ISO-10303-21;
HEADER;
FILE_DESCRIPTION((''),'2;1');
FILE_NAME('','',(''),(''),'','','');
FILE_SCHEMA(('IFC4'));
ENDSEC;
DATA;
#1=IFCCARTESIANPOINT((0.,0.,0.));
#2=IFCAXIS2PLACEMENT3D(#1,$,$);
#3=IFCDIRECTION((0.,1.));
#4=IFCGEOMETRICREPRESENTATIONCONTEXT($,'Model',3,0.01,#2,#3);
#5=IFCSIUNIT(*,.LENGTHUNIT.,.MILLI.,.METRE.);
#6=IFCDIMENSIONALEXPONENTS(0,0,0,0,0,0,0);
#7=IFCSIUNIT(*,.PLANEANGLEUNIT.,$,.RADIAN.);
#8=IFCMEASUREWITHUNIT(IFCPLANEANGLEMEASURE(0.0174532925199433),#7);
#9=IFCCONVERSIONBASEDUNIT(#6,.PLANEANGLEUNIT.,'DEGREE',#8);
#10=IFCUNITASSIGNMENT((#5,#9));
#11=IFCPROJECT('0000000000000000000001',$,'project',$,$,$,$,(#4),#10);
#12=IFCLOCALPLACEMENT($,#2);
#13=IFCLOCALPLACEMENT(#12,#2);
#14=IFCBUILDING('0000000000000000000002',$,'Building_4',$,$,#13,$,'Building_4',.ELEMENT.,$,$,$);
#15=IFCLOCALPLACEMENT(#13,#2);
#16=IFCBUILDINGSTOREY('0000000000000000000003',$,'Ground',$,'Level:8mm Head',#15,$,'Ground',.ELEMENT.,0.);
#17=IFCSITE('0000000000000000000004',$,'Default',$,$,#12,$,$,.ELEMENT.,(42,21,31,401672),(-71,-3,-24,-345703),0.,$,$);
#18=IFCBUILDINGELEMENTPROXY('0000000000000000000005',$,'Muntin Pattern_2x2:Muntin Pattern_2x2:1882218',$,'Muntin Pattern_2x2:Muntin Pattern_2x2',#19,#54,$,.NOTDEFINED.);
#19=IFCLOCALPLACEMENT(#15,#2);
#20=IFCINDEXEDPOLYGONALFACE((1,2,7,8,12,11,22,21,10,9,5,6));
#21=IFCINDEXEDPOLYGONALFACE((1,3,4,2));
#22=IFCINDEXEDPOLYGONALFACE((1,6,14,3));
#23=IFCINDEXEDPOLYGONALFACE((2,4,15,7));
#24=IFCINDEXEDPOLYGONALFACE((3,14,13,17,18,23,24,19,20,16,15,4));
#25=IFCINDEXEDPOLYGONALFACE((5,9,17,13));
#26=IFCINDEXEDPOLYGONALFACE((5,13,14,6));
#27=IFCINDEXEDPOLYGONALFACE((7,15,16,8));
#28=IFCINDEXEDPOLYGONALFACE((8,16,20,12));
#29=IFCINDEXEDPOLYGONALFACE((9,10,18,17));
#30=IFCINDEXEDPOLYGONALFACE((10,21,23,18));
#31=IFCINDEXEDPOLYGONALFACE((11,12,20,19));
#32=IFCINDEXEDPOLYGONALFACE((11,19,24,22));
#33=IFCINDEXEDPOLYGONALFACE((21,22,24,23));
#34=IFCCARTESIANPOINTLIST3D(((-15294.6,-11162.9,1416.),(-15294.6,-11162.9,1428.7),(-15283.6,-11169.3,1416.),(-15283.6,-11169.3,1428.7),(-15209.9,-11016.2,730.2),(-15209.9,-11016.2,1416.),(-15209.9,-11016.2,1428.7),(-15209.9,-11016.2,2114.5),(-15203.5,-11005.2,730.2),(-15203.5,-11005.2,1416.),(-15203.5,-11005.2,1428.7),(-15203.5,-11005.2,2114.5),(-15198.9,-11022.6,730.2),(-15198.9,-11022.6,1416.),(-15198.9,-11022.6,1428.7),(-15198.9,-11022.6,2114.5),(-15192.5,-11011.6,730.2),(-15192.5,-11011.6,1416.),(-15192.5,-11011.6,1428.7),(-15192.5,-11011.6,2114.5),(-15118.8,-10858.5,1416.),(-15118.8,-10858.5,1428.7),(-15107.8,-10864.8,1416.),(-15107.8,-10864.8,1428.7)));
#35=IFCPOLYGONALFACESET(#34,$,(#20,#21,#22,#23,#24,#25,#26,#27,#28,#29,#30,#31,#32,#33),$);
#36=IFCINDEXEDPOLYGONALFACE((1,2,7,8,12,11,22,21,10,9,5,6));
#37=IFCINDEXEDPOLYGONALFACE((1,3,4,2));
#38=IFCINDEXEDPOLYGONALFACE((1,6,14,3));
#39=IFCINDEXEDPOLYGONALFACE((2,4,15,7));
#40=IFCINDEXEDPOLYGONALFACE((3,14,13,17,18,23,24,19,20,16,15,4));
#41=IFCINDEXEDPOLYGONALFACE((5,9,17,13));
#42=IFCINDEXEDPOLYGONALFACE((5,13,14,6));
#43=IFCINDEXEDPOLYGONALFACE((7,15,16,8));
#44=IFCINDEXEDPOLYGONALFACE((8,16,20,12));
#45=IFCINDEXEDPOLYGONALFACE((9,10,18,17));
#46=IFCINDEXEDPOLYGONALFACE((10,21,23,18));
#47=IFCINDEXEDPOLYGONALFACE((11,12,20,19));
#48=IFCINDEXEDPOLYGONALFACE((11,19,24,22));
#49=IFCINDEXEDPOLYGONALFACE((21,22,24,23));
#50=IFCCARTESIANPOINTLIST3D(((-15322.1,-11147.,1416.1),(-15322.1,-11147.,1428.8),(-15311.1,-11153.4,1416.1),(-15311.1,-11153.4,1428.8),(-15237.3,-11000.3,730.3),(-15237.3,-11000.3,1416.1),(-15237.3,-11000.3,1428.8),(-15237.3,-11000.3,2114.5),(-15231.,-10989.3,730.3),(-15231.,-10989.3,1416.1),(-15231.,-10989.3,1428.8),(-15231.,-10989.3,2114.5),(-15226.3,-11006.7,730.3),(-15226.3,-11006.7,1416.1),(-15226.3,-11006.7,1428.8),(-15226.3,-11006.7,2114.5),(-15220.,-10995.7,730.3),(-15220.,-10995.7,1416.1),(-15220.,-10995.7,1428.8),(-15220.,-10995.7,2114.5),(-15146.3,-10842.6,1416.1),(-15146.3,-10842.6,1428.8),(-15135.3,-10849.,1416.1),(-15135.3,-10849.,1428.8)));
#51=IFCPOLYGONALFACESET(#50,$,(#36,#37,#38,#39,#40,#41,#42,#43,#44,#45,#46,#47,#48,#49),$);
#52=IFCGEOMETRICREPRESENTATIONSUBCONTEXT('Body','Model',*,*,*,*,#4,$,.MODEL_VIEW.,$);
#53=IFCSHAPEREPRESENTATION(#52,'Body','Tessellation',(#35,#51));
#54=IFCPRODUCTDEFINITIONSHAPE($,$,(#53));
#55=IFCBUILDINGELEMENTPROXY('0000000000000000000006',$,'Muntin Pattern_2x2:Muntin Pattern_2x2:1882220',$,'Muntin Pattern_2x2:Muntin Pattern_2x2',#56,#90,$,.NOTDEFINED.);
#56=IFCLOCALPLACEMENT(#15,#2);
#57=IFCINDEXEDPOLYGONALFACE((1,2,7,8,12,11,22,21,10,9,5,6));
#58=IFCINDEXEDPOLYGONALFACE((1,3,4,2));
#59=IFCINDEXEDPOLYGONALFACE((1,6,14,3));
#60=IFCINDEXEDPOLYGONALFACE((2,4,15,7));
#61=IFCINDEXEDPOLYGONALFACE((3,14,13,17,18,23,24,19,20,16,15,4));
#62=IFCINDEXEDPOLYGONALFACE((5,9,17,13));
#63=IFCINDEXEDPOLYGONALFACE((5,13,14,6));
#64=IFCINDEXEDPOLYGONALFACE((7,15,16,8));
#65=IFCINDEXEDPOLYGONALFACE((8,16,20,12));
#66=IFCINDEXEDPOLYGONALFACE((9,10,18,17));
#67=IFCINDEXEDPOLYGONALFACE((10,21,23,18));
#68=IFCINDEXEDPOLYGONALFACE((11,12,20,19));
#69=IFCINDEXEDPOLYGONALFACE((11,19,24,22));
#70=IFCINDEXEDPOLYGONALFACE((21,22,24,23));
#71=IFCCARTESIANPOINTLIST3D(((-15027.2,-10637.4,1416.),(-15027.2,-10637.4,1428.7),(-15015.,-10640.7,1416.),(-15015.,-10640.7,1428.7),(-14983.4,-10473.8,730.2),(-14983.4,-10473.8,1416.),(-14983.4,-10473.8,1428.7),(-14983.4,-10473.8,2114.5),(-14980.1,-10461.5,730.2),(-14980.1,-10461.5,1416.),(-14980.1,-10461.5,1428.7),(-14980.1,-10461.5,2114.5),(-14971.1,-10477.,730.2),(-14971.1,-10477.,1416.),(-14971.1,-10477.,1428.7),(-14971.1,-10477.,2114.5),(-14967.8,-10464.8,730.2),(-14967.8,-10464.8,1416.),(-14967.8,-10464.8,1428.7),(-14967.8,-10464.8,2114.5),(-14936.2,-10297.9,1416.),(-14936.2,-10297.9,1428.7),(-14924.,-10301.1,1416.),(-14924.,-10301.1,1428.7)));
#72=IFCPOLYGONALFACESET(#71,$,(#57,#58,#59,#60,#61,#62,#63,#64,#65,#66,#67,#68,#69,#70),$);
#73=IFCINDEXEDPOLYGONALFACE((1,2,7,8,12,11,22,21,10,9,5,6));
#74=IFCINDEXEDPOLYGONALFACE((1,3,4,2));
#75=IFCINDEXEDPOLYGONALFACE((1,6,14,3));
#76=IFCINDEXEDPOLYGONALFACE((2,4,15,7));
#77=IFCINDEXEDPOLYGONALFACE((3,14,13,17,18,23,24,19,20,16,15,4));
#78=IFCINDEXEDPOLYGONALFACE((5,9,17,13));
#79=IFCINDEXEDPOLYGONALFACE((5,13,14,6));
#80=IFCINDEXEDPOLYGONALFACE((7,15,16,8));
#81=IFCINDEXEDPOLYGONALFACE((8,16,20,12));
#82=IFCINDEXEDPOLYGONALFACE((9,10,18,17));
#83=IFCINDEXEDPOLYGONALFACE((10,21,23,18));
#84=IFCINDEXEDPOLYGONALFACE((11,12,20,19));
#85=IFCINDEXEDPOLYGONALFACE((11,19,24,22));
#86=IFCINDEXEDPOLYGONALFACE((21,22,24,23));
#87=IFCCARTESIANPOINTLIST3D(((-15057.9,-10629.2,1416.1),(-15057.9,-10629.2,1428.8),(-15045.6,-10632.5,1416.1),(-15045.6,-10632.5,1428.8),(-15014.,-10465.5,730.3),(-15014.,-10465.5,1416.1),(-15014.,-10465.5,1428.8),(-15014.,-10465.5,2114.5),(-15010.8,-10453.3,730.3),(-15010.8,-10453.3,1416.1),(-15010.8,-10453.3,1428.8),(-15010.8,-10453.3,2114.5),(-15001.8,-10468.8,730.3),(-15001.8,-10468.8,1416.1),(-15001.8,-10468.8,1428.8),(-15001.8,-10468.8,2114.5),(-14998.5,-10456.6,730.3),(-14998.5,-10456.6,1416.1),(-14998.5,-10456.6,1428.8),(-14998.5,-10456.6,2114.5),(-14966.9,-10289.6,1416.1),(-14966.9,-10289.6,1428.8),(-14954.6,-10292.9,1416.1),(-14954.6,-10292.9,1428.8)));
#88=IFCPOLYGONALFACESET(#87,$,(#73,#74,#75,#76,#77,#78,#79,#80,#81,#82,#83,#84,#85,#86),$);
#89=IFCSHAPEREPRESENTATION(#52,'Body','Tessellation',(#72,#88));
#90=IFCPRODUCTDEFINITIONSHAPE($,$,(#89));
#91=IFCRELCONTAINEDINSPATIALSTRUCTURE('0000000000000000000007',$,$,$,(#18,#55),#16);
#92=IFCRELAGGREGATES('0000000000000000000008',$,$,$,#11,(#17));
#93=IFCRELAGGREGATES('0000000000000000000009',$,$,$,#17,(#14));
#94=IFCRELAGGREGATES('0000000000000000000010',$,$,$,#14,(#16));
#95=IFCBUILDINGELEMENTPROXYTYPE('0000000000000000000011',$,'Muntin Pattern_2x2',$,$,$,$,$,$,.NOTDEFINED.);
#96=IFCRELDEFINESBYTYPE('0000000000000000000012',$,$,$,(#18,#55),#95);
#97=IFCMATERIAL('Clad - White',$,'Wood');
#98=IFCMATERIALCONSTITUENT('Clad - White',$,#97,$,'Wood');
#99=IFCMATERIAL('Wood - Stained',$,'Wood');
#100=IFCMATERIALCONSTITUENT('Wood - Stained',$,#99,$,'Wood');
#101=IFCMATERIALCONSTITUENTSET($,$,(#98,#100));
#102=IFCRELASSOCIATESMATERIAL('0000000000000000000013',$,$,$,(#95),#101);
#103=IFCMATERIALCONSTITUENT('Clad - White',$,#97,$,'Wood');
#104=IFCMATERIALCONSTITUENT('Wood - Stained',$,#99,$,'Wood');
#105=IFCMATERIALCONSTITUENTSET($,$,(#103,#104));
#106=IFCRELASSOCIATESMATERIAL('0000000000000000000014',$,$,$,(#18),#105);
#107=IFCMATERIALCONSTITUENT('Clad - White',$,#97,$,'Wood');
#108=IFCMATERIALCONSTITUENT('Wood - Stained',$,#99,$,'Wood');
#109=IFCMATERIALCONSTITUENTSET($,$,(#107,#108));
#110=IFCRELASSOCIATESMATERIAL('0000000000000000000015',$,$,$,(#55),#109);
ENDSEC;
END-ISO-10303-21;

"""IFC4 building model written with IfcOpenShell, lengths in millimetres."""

from ifc_helpers import new_model, entity, si_unit, converted_unit, direction, frame, origin, place, context, subcontext, project, spatial, indexed_curve, outline, extrude, source, transform, mapped, material, constituent, constituent_set, type_object, type_shapes, element, save


model = new_model("IFC4")

# Units and contexts
model_context = context("Model", 3, precision=0.01, world=origin(), true_north=direction((0.0, 1.0)))
body_context = subcontext(model_context, "Body", "Model", "MODEL_VIEW")
ifc_project = project(units=[si_unit("LENGTHUNIT", "METRE", prefix="MILLI"), converted_unit("PLANEANGLEUNIT", "DEGREE", entity("IfcPlaneAngleMeasure", 0.0174532925199433), si_unit("PLANEANGLEUNIT", "RADIAN"), dimensions=[0, 0, 0, 0, 0, 0, 0])], contexts=[model_context])

# Site, building, storey
site_placement = place(None, origin())
site = spatial("IfcSite", under=ifc_project, at=site_placement, Name="Default", CompositionType="ELEMENT", RefLatitude=(42, 21, 31, 401672), RefLongitude=(-71, -3, -24, -345703), RefElevation=0.0)
building_placement = place(site_placement, origin())
building = spatial("IfcBuilding", under=site, at=building_placement, Name="Building_4", LongName="Building_4", CompositionType="ELEMENT")
storey_placement = place(building_placement, origin())
storey = spatial("IfcBuildingStorey", under=building, at=storey_placement, Name="Ground", ObjectType="Level:8mm Head", LongName="Ground", CompositionType="ELEMENT", Elevation=0.0)

# Building element proxies
ifc_material_1 = material(Name="Clad - White", Category="Wood")
ifc_material_2 = material(Name="Wood - Stained", Category="Wood")
ifc_constituent_1 = constituent(ifc_material_1, Name="Clad - White", Category="Wood")
ifc_constituent_2 = constituent(ifc_material_2, Name="Wood - Stained", Category="Wood")
ifc_constituent_set_1 = constituent_set(constituents=[ifc_constituent_1, ifc_constituent_2])
building_element_proxy_type_1 = type_object("IfcBuildingElementProxyType", Name="Muntin Pattern_2x2", PredefinedType="NOTDEFINED", material=ifc_constituent_set_1)
shared_shape_1 = source(origin(), body_context, "Body", "SweptSolid", [
    extrude(outline(indexed_curve([(6.4, -6.4), (692.1, -6.4), (692.1, 6.3), (6.4, 6.3), (6.4, 175.8), (-6.3, 175.8), (-6.3, 6.3), (-692.2, 6.3), (-692.2, -6.4), (-6.3, -6.4), (-6.3, -175.8), (6.4, -175.8), (6.4, -6.4)], self_intersect=False)), frame((0.0, -22.2, 692.1), z_axis=(0.0, 1.0, 0.0), x_axis=(0.0, 0.0, 1.0)), (0.0, 0.0, 1.0), 12.7),
    extrude(outline(indexed_curve([(6.4, -6.4), (692.1, -6.4), (692.1, 6.3), (6.4, 6.3), (6.4, 175.8), (-6.3, 175.8), (-6.3, 6.3), (-692.1, 6.3), (-692.1, -6.4), (-6.3, -6.4), (-6.3, -175.8), (6.4, -175.8), (6.4, -6.4)], self_intersect=False)), frame((0.0, 9.5, 692.1), z_axis=(0.0, 1.0, 0.0), x_axis=(0.0, 0.0, 1.0)), (0.0, 0.0, 1.0), 12.7),
])
type_shapes(building_element_proxy_type_1, [shared_shape_1])
ifc_constituent_3 = constituent(ifc_material_1, Name="Clad - White", Category="Wood")
ifc_constituent_4 = constituent(ifc_material_2, Name="Wood - Stained", Category="Wood")
ifc_constituent_set_2 = constituent_set(constituents=[ifc_constituent_3, ifc_constituent_4])
proxy_1_placement = place(storey_placement, frame((-15214.9, -11005.9, 730.3), z_axis=(0.0, 0.0, 1.0), x_axis=(0.5, 0.866025, 0.0)))
element("IfcBuildingElementProxy", 1, at=proxy_1_placement, inside=storey, type_object=building_element_proxy_type_1, material=ifc_constituent_set_2, Name="Muntin Pattern_2x2:Muntin Pattern_2x2:1882218", ObjectType="Muntin Pattern_2x2:Muntin Pattern_2x2", PredefinedType="NOTDEFINED", context=body_context, shape_type="MappedRepresentation", body=[
    mapped(shared_shape_1, transform((0.0, 0.0, 0.0), scale=1.0)),
])
ifc_constituent_5 = constituent(ifc_material_1, Name="Clad - White", Category="Wood")
ifc_constituent_6 = constituent(ifc_material_2, Name="Wood - Stained", Category="Wood")
ifc_constituent_set_3 = constituent_set(constituents=[ifc_constituent_5, ifc_constituent_6])
proxy_2_placement = place(storey_placement, frame((-14990.9, -10465.2, 730.3), z_axis=(0.0, 0.0, 1.0), x_axis=(0.258819, 0.965926, 0.0)))
element("IfcBuildingElementProxy", 2, at=proxy_2_placement, inside=storey, type_object=building_element_proxy_type_1, material=ifc_constituent_set_3, Name="Muntin Pattern_2x2:Muntin Pattern_2x2:1882220", ObjectType="Muntin Pattern_2x2:Muntin Pattern_2x2", PredefinedType="NOTDEFINED", context=body_context, shape_type="MappedRepresentation", body=[
    mapped(shared_shape_1, transform((0.0, 0.0, 0.0), scale=1.0)),
])

save(model, "model.ifc")
